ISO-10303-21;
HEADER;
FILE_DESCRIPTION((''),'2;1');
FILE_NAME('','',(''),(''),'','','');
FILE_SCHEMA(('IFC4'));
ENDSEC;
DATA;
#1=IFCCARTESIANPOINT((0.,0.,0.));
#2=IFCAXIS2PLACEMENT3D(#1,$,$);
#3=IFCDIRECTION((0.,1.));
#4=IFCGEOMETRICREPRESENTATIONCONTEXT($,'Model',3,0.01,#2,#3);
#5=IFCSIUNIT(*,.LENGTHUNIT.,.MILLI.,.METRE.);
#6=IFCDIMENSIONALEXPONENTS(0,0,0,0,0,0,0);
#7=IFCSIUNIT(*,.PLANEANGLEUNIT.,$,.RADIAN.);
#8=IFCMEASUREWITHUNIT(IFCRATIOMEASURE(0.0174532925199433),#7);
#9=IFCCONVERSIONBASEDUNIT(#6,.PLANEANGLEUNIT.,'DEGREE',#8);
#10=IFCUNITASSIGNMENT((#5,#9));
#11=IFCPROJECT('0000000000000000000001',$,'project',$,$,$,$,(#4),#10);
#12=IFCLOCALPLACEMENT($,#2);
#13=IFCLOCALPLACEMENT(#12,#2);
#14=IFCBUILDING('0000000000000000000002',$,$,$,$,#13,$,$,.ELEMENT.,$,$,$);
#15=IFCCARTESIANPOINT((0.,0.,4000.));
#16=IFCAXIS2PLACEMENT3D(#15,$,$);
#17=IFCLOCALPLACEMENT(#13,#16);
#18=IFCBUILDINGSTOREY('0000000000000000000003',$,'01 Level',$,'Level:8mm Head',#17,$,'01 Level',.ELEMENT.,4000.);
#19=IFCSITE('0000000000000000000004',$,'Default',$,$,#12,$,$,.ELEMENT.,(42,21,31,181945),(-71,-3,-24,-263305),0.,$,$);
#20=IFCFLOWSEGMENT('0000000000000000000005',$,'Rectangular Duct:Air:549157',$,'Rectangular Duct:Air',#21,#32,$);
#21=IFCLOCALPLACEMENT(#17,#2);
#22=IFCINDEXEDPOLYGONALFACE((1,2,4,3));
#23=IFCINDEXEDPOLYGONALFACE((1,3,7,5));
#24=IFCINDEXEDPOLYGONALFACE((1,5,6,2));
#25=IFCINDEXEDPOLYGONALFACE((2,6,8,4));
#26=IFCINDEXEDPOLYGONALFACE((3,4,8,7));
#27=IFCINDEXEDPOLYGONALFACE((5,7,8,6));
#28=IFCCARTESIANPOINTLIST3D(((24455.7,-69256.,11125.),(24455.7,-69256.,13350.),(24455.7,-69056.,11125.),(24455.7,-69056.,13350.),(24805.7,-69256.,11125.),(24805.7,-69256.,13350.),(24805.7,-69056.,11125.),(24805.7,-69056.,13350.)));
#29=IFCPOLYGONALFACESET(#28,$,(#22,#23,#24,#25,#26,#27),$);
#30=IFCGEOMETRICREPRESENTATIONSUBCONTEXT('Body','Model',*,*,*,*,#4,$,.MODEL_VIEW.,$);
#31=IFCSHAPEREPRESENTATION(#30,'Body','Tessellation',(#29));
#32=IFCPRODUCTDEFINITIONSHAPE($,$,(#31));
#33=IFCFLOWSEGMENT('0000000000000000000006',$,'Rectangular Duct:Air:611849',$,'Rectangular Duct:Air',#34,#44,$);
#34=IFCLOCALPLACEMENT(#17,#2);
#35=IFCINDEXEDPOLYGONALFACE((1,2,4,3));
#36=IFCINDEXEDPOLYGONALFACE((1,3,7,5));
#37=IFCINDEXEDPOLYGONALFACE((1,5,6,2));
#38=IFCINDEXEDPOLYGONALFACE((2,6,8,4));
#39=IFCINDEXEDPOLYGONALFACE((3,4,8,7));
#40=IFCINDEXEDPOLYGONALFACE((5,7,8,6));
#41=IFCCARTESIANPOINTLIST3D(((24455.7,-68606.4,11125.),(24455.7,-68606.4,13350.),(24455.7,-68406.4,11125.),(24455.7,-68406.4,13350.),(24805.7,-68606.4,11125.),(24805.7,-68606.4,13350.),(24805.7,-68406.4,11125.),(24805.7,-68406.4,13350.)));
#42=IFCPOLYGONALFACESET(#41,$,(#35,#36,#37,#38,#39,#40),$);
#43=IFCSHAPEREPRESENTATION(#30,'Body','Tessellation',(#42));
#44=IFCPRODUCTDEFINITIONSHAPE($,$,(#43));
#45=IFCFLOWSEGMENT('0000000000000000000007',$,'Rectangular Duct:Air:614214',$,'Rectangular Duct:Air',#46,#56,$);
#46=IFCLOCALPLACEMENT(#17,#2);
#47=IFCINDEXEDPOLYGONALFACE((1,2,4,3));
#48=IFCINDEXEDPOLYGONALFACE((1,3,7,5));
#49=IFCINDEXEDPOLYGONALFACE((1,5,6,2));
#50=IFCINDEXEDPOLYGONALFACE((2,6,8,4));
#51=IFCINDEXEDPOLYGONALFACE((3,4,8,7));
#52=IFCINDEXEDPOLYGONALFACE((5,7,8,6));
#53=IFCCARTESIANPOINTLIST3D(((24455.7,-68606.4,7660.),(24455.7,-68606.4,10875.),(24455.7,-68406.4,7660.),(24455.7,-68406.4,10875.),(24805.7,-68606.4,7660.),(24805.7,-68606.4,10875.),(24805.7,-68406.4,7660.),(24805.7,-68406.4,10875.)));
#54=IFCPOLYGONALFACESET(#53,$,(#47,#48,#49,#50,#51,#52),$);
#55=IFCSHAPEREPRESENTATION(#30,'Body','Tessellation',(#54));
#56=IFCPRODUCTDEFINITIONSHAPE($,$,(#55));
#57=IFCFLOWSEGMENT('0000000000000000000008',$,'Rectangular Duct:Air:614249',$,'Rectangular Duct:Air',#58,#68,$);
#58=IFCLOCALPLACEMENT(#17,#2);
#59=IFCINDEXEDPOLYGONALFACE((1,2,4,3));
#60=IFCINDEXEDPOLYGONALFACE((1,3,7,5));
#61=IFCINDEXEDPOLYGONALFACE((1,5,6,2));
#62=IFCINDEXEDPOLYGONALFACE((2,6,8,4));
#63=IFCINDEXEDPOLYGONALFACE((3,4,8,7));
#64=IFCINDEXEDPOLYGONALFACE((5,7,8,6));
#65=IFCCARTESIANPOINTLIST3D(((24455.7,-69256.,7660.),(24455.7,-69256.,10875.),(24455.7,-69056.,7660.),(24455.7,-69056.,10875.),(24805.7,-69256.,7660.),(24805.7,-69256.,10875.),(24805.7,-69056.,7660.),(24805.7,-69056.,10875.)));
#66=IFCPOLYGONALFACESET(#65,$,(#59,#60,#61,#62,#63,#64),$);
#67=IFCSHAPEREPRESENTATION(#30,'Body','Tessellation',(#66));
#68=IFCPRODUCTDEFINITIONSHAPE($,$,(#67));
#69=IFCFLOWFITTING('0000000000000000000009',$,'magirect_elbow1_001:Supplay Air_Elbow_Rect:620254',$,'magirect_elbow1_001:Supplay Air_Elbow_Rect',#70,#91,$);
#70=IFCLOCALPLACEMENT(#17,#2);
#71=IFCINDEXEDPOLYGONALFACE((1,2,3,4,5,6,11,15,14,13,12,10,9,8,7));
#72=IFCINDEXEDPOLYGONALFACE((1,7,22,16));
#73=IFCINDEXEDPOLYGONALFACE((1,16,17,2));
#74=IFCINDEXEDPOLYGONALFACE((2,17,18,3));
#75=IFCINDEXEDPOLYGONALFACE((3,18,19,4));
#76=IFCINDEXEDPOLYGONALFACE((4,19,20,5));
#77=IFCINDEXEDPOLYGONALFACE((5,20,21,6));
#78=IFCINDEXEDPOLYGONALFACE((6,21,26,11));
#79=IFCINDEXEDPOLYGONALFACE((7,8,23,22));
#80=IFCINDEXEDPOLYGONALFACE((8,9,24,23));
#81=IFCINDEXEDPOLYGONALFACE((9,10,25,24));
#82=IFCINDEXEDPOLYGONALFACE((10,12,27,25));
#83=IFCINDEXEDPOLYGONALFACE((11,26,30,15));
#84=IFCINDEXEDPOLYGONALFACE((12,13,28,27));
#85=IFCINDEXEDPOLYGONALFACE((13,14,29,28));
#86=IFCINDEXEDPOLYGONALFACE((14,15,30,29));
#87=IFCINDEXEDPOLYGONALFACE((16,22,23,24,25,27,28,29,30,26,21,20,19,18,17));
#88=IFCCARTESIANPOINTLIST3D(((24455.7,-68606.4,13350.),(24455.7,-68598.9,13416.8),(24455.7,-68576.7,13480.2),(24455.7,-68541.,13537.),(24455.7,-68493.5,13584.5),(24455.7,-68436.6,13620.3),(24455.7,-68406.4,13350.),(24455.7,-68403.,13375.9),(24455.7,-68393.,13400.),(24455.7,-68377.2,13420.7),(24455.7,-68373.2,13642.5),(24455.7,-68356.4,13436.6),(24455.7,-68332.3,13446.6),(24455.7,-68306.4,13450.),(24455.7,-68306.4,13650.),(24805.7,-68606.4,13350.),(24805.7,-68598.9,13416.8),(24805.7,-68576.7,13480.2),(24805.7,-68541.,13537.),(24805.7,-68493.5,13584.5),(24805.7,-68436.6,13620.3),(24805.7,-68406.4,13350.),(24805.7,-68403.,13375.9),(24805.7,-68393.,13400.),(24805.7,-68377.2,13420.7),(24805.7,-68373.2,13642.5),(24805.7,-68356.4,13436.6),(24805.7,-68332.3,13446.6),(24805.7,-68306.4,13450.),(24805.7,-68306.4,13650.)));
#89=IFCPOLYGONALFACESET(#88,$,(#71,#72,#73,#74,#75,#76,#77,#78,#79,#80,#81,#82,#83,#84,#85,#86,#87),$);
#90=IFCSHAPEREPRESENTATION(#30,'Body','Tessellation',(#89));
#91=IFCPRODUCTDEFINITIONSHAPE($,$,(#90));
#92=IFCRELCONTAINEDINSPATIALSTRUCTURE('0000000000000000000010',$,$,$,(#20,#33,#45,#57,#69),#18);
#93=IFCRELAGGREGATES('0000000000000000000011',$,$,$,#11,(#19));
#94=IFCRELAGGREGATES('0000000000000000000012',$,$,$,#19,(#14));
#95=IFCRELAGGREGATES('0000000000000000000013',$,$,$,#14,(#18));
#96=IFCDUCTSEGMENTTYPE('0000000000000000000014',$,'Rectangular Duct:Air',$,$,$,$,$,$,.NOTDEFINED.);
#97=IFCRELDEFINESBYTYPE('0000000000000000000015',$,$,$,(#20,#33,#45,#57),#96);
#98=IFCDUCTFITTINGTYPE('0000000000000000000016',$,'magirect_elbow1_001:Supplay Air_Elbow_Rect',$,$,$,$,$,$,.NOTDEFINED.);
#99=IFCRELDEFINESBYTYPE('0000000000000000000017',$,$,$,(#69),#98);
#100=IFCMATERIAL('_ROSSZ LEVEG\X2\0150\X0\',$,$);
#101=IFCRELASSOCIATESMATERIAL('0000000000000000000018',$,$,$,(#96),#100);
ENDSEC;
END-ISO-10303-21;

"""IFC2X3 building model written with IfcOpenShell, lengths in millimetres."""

from ifc_helpers import new_model, entity, si_unit, converted_unit, direction, frame, frame_2d, origin, place, context, subcontext, project, spatial, polyline, circle_curve, parameter, trimmed, segment, composite_curve, rectangle, outline, extrude, source, transform, mapped, material, type_object, type_shapes, element, save


model = new_model("IFC2X3")

# Units and contexts
model_context = context("Model", 3, precision=0.01, world=origin(), true_north=direction((0.0, 1.0)))
body_context = subcontext(model_context, "Body", "Model", "MODEL_VIEW")
ifc_project = project(units=[si_unit("LENGTHUNIT", "METRE", prefix="MILLI"), converted_unit("PLANEANGLEUNIT", "DEGREE", entity("IfcRatioMeasure", 0.0174532925199433), si_unit("PLANEANGLEUNIT", "RADIAN"), dimensions=[0, 0, 0, 0, 0, 0, 0])], contexts=[model_context])

# Site, building, storey
site_placement = place(None, origin())
site = spatial("IfcSite", under=ifc_project, at=site_placement, Name="Default", CompositionType="ELEMENT", RefLatitude=(42, 21, 31, 181945), RefLongitude=(-71, -3, -24, -263305), RefElevation=0.0)
building_placement = place(site_placement, origin())
building = spatial("IfcBuilding", under=site, at=building_placement, CompositionType="ELEMENT")
storey_placement = place(building_placement, frame((0.0, 0.0, 4000.0)))
storey = spatial("IfcBuildingStorey", under=building, at=storey_placement, Name="01 Level", ObjectType="Level:8mm Head", LongName="01 Level", CompositionType="ELEMENT", Elevation=4000.0)

# Flow segments
ifc_material = material(Name="_ROSSZ LEVEGŐ")
duct_segment_type = type_object("IfcDuctSegmentType", Name="Rectangular Duct:Air", PredefinedType="NOTDEFINED", material=ifc_material)
flow_segment_1_placement = place(storey_placement, origin())
element("IfcFlowSegment", 1, at=flow_segment_1_placement, inside=storey, type_object=duct_segment_type, Name="Rectangular Duct:Air:549157", ObjectType="Rectangular Duct:Air", context=body_context, shape_type="SweptSolid", body=[
    extrude(rectangle(XDim=350.0, YDim=200.0, at=frame_2d((0.0, 0.0), x_axis=(1.0, 0.0))), frame((24630.7, -69156.0, 11125.0)), (0.0, 0.0, 1.0), 2225.0),
])
flow_segment_2_placement = place(storey_placement, origin())
element("IfcFlowSegment", 2, at=flow_segment_2_placement, inside=storey, type_object=duct_segment_type, Name="Rectangular Duct:Air:611849", ObjectType="Rectangular Duct:Air", context=body_context, shape_type="SweptSolid", body=[
    extrude(rectangle(XDim=200.0, YDim=350.0, at=frame_2d((0.0, 0.0), x_axis=(1.0, 0.0))), frame((24630.7, -68506.4, 11125.0), z_axis=(0.0, 0.0, 1.0), x_axis=(0.0, -1.0, 0.0)), (0.0, 0.0, 1.0), 2225.0),
])
flow_segment_3_placement = place(storey_placement, origin())
element("IfcFlowSegment", 3, at=flow_segment_3_placement, inside=storey, type_object=duct_segment_type, Name="Rectangular Duct:Air:614214", ObjectType="Rectangular Duct:Air", context=body_context, shape_type="SweptSolid", body=[
    extrude(rectangle(XDim=200.0, YDim=350.0, at=frame_2d((0.0, 0.0), x_axis=(1.0, 0.0))), frame((24630.7, -68506.4, 7660.0), z_axis=(0.0, 0.0, 1.0), x_axis=(0.0, -1.0, 0.0)), (0.0, 0.0, 1.0), 3215.0),
])
flow_segment_4_placement = place(storey_placement, origin())
element("IfcFlowSegment", 4, at=flow_segment_4_placement, inside=storey, type_object=duct_segment_type, Name="Rectangular Duct:Air:614249", ObjectType="Rectangular Duct:Air", context=body_context, shape_type="SweptSolid", body=[
    extrude(rectangle(XDim=200.0, YDim=350.0, at=frame_2d((0.0, 0.0), x_axis=(1.0, 0.0))), frame((24630.7, -69156.0, 7660.0), z_axis=(0.0, 0.0, 1.0), x_axis=(0.0, 1.0, 0.0)), (0.0, 0.0, 1.0), 3215.0),
])

# Flow fitting
duct_fitting_type = type_object("IfcDuctFittingType", Name="magirect_elbow1_001:Supplay Air_Elbow_Rect", PredefinedType="NOTDEFINED")
shared_shape = source(origin(), body_context, "Body", "SweptSolid", [
    extrude(outline(composite_curve([segment(polyline([(-200.0, -100.0), (0.0, -100.0)]), True, "CONTINUOUS"), segment(trimmed(circle_curve(frame_2d((100.0, -100.0), x_axis=(0.0, 1.0)), 100.0), [parameter(0.0)], [parameter(90.0)], True, "PARAMETER"), False, "CONTINUOUS"), segment(polyline([(100.0, 0.0), (100.0, 200.0)]), True, "CONTINUOUS"), segment(trimmed(circle_curve(frame_2d((100.0, -100.0), x_axis=(0.0, 1.0)), 300.0), [parameter(0.0)], [parameter(90.0)], True, "PARAMETER"), True, "CONTINUOUS")], self_intersect=False)), frame((-100.0, 100.0, -175.0), z_axis=(0.0, 0.0, 1.0), x_axis=(-1.0, 0.0, 0.0)), (0.0, 0.0, 1.0), 350.0),
])
type_shapes(duct_fitting_type, [shared_shape])
flow_fitting_placement = place(storey_placement, frame((24630.7, -68506.4, 13550.0), z_axis=(-1.0, 0.0, 0.0), x_axis=(0.0, 0.0, 1.0)))
element("IfcFlowFitting", 5, at=flow_fitting_placement, inside=storey, type_object=duct_fitting_type, Name="magirect_elbow1_001:Supplay Air_Elbow_Rect:620254", ObjectType="magirect_elbow1_001:Supplay Air_Elbow_Rect", context=body_context, shape_type="MappedRepresentation", body=[
    mapped(shared_shape, transform((0.0, 0.0, 0.0), scale=1.0)),
])

save(model, "model.ifc")
